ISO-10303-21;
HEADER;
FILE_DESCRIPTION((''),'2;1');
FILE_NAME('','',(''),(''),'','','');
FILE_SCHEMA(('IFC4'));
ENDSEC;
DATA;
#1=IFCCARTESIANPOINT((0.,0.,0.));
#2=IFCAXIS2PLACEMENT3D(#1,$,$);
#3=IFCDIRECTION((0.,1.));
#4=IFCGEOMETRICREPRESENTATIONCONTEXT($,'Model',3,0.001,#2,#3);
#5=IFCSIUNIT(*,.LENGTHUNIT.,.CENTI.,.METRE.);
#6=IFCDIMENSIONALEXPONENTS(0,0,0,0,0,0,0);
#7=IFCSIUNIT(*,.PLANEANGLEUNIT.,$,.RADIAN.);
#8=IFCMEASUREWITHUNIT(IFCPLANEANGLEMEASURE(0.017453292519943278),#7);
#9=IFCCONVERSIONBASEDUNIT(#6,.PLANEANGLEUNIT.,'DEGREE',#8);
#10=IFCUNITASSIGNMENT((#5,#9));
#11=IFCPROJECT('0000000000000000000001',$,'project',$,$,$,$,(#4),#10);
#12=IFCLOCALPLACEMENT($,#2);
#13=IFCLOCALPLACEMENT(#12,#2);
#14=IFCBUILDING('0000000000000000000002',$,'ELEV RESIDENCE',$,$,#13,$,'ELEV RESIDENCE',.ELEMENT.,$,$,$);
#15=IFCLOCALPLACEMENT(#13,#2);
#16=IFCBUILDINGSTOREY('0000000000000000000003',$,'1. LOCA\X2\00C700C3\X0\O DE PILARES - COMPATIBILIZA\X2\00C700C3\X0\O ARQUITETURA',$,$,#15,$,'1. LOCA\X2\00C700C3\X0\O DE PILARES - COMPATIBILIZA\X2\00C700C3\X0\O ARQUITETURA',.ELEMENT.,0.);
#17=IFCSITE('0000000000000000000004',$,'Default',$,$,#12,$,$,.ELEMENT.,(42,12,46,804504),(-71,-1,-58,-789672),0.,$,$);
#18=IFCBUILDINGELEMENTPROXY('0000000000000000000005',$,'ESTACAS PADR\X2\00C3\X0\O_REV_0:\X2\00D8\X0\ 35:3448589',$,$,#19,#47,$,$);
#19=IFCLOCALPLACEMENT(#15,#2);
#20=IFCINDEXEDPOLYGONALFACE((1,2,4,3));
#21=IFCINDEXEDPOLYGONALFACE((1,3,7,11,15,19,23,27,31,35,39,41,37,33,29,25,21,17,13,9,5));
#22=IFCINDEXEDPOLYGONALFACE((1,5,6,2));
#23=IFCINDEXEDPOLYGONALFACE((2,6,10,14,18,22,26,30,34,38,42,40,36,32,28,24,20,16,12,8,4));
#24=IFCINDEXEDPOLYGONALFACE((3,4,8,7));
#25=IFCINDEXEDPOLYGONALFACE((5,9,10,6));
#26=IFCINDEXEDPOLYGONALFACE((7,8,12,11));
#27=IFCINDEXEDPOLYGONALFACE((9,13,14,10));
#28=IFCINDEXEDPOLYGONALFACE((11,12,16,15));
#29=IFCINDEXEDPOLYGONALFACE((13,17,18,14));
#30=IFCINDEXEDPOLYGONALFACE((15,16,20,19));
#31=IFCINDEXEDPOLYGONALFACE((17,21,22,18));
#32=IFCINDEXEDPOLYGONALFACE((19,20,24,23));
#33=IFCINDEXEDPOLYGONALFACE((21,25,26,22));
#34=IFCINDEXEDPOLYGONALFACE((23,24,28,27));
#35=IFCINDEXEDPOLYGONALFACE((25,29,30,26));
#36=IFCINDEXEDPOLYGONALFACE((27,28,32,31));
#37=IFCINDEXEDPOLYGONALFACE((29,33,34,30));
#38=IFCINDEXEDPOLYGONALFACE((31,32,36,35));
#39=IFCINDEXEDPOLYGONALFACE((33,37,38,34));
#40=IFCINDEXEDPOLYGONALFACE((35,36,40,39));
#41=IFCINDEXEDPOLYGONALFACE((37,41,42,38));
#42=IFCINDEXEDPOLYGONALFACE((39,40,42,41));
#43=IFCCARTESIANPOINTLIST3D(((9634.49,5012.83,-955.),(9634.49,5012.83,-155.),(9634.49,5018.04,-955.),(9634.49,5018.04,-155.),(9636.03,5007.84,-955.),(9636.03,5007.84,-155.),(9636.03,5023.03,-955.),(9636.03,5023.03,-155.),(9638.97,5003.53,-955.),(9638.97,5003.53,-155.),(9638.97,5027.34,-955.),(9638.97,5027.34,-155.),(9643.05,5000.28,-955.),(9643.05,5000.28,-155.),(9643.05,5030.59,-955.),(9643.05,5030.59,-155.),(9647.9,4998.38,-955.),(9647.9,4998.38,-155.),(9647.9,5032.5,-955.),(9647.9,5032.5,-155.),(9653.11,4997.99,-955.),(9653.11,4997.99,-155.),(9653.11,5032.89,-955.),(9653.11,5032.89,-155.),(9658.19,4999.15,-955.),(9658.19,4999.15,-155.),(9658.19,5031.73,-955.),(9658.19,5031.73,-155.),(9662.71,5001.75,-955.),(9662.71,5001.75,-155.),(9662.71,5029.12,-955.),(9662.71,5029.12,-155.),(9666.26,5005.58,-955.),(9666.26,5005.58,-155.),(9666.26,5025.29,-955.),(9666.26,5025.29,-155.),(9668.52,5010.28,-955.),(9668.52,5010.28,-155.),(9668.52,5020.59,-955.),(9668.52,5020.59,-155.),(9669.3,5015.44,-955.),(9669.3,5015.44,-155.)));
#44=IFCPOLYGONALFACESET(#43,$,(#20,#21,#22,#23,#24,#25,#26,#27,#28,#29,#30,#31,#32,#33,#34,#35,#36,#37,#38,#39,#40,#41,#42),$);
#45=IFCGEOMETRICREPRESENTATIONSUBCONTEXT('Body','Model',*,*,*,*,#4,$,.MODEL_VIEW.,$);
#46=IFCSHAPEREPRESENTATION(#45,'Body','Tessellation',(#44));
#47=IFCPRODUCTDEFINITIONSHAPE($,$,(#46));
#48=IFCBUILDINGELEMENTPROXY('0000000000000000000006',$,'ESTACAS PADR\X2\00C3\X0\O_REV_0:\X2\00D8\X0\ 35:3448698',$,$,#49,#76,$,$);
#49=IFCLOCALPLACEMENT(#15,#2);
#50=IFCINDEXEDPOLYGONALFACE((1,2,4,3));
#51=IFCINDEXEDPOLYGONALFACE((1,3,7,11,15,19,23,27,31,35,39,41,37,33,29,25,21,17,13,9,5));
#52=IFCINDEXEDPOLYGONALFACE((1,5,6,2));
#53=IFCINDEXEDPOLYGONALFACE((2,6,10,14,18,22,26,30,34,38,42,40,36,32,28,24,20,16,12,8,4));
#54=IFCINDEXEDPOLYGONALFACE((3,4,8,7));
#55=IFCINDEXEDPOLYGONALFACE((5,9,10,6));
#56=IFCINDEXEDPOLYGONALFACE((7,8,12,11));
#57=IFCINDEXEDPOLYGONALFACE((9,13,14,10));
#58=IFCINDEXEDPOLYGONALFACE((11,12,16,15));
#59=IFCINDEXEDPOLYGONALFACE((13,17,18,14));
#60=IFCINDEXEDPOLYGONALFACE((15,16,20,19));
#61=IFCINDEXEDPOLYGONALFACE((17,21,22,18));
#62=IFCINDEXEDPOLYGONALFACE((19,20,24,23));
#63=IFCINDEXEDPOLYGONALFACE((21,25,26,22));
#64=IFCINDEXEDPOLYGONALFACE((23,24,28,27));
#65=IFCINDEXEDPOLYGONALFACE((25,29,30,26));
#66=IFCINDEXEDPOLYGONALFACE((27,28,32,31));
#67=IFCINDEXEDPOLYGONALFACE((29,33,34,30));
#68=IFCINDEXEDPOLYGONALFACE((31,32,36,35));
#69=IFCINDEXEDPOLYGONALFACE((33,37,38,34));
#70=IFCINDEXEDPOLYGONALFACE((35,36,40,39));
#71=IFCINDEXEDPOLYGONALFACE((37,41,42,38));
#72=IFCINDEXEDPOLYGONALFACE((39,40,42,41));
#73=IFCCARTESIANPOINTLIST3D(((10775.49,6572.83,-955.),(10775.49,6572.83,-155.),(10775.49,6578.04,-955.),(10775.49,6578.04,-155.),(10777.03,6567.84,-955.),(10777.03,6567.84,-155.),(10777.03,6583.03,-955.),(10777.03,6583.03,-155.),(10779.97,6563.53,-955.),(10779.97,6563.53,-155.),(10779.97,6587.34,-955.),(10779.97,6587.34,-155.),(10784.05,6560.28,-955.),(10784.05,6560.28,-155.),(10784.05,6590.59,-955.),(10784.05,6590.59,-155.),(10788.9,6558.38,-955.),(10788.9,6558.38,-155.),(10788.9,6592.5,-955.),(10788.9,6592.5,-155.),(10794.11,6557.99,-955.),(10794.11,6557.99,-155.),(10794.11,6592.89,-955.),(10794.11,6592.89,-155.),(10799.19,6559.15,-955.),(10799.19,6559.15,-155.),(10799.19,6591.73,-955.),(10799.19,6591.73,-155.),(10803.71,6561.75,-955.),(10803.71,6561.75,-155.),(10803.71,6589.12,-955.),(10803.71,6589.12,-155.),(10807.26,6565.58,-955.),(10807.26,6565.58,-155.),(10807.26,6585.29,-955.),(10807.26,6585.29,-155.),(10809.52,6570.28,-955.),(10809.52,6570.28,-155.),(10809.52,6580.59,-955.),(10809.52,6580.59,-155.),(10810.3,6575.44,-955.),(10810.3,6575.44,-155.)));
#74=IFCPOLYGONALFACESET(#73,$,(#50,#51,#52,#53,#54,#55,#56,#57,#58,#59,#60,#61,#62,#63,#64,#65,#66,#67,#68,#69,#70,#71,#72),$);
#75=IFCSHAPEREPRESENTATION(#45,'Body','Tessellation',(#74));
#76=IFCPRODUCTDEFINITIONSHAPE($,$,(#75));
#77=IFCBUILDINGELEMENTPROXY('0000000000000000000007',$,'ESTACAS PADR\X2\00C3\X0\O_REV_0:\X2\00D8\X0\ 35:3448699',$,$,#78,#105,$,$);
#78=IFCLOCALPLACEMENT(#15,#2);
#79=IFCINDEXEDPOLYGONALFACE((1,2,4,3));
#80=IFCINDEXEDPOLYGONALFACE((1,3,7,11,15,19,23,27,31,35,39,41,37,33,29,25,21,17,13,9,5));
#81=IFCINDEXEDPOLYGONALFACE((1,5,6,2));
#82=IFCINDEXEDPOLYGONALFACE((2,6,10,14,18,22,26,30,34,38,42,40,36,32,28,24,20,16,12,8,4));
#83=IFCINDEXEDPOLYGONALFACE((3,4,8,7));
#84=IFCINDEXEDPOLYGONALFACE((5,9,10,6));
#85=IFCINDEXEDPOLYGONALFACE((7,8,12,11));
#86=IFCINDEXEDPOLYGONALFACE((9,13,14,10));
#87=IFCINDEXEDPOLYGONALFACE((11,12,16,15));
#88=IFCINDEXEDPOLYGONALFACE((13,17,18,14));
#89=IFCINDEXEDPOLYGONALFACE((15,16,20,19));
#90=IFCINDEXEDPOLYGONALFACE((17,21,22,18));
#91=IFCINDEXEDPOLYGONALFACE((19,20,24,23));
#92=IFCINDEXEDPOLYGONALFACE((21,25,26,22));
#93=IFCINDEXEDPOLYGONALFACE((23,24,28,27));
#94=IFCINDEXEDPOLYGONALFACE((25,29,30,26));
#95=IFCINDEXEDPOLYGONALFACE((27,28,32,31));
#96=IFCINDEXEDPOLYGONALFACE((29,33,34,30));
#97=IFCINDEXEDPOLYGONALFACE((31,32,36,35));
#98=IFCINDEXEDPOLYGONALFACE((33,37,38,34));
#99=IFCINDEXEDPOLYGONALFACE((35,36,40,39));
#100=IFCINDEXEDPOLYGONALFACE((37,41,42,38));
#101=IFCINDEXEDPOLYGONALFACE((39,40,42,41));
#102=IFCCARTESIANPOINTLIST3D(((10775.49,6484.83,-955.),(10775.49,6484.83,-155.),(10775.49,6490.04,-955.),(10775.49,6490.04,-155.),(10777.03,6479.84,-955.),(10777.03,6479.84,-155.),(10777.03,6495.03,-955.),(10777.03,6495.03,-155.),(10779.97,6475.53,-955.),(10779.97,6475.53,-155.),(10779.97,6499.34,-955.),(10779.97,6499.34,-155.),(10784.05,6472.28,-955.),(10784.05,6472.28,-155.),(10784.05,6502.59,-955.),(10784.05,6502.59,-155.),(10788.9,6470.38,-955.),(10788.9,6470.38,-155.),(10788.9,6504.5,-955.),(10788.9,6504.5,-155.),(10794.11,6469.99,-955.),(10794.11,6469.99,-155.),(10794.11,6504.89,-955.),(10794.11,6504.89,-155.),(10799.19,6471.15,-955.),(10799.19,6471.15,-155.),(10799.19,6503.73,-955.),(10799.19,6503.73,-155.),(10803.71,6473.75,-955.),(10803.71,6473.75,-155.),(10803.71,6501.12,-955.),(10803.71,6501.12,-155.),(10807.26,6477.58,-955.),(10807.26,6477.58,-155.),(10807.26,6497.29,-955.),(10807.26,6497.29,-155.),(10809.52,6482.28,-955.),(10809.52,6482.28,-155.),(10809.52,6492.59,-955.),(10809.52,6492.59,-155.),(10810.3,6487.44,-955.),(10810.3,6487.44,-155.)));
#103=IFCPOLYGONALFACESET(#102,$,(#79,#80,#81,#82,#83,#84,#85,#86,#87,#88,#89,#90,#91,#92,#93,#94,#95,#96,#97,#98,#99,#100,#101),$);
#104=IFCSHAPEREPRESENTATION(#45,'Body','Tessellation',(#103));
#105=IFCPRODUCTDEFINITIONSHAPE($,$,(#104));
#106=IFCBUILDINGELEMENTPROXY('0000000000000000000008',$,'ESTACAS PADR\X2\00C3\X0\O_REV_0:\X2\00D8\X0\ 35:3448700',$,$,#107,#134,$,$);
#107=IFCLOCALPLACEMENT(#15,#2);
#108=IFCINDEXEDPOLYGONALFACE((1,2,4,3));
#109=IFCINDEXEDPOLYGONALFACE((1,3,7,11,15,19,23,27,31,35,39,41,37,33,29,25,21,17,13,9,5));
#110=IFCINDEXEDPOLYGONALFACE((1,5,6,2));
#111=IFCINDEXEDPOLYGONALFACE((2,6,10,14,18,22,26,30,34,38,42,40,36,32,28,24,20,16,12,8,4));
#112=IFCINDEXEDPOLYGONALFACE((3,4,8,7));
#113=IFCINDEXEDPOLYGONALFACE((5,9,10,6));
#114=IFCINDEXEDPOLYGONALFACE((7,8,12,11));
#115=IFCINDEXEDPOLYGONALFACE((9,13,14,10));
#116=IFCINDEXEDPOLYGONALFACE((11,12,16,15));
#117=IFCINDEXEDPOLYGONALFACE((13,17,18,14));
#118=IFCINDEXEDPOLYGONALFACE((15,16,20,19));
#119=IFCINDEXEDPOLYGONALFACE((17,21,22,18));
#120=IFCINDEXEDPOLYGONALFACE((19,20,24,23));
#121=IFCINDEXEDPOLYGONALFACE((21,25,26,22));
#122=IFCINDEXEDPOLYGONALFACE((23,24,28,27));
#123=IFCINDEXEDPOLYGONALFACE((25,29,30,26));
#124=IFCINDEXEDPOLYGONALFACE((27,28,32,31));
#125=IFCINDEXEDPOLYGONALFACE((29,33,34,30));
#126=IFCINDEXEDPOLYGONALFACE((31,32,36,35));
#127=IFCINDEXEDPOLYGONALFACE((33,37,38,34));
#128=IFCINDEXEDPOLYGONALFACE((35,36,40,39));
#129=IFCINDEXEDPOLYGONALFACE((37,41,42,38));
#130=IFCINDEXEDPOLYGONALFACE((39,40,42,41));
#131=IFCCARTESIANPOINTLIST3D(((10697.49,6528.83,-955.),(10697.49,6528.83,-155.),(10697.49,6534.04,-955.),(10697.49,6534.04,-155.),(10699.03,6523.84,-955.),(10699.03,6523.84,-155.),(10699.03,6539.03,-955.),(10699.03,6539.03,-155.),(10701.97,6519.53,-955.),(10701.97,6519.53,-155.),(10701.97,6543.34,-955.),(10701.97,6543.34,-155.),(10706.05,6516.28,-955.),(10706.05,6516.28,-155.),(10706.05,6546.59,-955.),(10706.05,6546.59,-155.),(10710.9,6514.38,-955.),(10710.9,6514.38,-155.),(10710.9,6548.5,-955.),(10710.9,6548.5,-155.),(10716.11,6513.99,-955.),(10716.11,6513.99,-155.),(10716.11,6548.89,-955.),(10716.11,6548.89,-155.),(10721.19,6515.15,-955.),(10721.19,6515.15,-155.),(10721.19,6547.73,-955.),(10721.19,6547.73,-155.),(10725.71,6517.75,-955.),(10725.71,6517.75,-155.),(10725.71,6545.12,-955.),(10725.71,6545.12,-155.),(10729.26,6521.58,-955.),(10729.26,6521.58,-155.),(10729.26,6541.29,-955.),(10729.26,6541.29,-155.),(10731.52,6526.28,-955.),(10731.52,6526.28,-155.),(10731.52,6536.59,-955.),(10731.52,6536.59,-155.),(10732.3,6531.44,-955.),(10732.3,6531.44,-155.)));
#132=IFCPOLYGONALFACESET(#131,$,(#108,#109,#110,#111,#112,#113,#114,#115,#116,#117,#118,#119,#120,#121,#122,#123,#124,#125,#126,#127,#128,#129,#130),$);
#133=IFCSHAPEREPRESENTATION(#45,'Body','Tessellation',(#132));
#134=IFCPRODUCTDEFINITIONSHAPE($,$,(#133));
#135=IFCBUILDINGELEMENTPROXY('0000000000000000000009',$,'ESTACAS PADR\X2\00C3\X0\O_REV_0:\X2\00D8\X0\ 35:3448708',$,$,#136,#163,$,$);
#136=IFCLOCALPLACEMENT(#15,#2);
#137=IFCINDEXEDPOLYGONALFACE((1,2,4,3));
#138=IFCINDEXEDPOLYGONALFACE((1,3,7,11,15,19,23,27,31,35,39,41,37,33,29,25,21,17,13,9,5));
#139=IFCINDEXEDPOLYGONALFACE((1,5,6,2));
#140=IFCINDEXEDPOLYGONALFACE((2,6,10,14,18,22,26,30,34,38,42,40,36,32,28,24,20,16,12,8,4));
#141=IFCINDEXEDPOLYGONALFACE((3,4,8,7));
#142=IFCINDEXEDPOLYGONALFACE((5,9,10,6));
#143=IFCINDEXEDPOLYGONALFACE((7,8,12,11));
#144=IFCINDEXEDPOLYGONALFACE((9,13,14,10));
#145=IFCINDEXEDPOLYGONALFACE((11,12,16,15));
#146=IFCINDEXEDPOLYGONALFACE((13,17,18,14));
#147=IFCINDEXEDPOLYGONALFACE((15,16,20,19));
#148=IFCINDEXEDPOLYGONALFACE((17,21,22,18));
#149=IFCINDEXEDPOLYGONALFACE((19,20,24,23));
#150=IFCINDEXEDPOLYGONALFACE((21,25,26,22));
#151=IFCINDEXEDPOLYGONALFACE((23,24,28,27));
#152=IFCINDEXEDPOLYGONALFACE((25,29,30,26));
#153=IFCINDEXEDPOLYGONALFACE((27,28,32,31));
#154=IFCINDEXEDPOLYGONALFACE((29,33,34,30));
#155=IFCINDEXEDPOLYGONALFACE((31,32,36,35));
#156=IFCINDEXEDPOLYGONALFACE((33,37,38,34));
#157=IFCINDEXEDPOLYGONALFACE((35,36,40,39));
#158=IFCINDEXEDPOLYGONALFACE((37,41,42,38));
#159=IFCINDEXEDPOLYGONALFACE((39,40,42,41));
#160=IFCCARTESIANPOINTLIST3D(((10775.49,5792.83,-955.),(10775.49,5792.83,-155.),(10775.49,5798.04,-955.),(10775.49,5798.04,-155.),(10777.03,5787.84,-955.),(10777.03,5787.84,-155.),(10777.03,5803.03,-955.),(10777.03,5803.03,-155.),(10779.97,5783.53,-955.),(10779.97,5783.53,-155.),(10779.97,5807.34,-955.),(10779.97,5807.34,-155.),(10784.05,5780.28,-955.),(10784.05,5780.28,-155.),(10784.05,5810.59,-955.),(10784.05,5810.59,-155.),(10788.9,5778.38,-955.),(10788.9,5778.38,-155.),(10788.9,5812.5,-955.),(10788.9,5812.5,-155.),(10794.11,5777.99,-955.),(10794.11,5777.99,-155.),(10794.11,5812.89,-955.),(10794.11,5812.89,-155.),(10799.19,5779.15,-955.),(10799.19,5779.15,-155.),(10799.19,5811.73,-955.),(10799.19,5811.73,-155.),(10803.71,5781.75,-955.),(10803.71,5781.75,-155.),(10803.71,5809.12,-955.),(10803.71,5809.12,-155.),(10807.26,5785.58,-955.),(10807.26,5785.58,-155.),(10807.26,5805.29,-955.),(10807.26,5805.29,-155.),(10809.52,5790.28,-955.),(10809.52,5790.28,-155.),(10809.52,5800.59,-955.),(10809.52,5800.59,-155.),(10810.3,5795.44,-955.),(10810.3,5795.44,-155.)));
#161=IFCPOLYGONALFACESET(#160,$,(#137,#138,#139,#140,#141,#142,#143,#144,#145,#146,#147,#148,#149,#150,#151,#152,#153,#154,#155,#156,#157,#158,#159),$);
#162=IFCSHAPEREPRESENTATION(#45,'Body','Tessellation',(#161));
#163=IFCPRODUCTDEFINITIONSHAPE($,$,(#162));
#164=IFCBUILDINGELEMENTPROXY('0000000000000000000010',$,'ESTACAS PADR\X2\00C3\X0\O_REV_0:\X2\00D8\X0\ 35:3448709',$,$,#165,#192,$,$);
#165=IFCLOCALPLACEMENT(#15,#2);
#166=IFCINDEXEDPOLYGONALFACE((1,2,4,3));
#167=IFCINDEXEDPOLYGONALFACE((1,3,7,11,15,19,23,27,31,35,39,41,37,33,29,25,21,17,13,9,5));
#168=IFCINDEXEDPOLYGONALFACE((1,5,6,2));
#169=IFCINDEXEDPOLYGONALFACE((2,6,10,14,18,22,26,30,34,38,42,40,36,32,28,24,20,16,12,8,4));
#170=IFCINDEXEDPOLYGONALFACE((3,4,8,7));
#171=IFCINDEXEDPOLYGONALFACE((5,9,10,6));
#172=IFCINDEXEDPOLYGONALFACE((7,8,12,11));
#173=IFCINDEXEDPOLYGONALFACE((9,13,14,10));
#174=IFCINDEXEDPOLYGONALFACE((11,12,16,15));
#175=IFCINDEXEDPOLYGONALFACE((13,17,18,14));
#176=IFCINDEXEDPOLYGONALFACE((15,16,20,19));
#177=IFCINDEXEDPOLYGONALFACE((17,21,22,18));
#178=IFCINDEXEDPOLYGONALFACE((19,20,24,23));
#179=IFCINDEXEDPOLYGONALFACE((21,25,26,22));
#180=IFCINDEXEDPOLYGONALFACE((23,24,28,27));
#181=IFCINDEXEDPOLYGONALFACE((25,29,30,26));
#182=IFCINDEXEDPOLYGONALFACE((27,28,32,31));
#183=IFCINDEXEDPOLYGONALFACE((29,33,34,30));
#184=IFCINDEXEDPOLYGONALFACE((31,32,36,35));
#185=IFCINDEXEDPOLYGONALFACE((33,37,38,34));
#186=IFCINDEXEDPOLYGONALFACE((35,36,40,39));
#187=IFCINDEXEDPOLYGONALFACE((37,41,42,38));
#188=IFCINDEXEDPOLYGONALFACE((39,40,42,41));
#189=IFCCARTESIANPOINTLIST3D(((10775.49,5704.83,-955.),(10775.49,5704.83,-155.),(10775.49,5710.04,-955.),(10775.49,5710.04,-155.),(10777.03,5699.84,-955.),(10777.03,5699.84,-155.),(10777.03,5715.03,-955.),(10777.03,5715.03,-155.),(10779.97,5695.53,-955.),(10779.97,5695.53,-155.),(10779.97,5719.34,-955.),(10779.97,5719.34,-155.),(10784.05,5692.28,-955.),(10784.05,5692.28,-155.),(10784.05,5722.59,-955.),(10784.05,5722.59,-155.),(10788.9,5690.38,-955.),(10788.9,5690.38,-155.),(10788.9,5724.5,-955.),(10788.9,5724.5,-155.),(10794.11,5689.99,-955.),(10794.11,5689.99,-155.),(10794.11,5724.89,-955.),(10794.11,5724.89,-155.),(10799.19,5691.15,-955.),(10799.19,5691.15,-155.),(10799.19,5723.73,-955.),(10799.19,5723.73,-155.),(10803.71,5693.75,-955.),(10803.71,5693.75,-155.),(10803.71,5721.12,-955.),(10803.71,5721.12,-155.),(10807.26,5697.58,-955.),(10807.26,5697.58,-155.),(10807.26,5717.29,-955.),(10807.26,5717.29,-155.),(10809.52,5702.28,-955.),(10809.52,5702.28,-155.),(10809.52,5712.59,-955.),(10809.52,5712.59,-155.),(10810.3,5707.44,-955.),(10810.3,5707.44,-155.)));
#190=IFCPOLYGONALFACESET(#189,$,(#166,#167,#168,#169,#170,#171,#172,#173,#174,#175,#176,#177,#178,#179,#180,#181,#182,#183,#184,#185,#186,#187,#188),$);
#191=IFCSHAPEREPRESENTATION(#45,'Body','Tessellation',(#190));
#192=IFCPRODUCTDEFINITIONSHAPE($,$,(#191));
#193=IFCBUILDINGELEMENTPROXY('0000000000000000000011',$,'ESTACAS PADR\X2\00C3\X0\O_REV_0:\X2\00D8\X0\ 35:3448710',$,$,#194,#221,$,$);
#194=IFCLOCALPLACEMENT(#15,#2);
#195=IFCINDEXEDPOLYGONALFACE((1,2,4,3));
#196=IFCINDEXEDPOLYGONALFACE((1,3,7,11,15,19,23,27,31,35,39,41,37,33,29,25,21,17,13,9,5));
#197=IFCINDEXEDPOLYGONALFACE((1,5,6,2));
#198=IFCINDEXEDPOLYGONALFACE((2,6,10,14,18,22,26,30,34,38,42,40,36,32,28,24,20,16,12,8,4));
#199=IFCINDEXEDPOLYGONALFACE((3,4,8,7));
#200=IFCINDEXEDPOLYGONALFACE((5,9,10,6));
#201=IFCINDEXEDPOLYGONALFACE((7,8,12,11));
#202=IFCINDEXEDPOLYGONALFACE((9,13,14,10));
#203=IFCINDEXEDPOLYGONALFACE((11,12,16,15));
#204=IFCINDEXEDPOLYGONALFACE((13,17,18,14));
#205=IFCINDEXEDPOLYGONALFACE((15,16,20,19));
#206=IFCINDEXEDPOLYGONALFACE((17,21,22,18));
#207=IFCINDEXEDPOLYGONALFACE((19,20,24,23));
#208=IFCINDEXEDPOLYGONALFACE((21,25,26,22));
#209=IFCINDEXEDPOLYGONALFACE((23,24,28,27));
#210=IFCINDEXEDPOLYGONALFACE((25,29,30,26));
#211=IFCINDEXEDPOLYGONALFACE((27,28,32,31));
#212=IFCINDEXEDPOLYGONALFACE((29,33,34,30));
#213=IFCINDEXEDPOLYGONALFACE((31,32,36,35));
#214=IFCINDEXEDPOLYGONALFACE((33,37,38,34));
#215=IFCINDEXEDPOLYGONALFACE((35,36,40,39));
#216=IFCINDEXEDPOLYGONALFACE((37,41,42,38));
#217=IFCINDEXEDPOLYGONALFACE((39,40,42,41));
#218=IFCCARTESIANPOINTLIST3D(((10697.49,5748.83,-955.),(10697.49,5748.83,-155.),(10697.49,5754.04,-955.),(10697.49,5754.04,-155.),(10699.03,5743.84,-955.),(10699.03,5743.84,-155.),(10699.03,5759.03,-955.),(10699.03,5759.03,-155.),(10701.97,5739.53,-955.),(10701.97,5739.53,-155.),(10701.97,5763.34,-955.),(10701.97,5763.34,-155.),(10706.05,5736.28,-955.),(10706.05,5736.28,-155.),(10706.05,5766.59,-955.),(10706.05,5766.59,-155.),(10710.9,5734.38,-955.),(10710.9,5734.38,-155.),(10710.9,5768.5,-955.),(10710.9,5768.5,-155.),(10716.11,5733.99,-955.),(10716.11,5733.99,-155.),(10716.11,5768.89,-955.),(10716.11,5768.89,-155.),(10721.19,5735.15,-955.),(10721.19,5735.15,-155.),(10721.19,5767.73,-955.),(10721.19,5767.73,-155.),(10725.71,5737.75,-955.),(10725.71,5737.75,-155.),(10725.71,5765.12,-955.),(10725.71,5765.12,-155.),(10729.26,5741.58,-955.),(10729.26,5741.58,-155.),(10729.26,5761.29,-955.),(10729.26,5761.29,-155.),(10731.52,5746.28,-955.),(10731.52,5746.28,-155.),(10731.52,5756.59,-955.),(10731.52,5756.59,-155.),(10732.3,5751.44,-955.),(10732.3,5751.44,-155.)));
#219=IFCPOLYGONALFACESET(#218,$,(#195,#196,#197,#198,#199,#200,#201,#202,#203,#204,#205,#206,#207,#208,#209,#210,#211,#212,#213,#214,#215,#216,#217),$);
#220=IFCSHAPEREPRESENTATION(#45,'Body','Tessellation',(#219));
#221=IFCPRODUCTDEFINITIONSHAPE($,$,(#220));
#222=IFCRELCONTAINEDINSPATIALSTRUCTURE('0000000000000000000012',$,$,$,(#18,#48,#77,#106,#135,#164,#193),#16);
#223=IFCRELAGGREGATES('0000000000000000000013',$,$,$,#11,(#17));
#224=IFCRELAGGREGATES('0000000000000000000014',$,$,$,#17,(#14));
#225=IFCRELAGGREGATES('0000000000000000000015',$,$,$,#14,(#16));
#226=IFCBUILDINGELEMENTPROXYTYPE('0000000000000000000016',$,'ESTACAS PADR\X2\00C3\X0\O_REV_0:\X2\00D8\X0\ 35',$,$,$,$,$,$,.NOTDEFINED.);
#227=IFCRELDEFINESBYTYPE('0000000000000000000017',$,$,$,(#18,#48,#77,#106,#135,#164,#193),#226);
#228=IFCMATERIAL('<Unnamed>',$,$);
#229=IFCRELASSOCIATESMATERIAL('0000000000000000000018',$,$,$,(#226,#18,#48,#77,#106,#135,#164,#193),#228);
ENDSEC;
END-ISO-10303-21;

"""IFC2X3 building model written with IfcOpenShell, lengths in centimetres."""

from ifc_helpers import new_model, entity, si_unit, converted_unit, direction, frame, frame_2d, origin, place, context, subcontext, project, spatial, circle, extrude, source, transform, mapped, material, type_object, type_shapes, element, save


model = new_model("IFC2X3")

# Units and contexts
model_context = context("Model", 3, precision=0.001, world=origin(), true_north=direction((0.0, 1.0)))
body_context = subcontext(model_context, "Body", "Model", "MODEL_VIEW")
ifc_project = project(units=[si_unit("LENGTHUNIT", "METRE", prefix="CENTI"), converted_unit("PLANEANGLEUNIT", "DEGREE", entity("IfcPlaneAngleMeasure", 0.017453292519943278), si_unit("PLANEANGLEUNIT", "RADIAN"), dimensions=[0, 0, 0, 0, 0, 0, 0])], contexts=[model_context])

# Site, building, storey
site_placement = place(None, origin())
site = spatial("IfcSite", under=ifc_project, at=site_placement, Name="Default", CompositionType="ELEMENT", RefLatitude=(42, 12, 46, 804504), RefLongitude=(-71, -1, -58, -789672), RefElevation=0.0)
building_placement = place(site_placement, origin())
building = spatial("IfcBuilding", under=site, at=building_placement, Name="ELEV RESIDENCE", LongName="ELEV RESIDENCE", CompositionType="ELEMENT")
storey_placement = place(building_placement, origin())
storey = spatial("IfcBuildingStorey", under=building, at=storey_placement, Name="1. LOCAÇÃO DE PILARES - COMPATIBILIZAÇÃO ARQUITETURA", LongName="1. LOCAÇÃO DE PILARES - COMPATIBILIZAÇÃO ARQUITETURA", CompositionType="ELEMENT", Elevation=0.0)

# Building element proxies
ifc_material_1 = material(Name="<Unnamed>")
building_element_proxy_type_1 = type_object("IfcBuildingElementProxyType", Name="ESTACAS PADRÃO_REV_0:Ø 35", PredefinedType="NOTDEFINED", material=ifc_material_1)
shared_shape_1 = source(origin(), body_context, "Body", "SweptSolid", [
    extrude(circle(Radius=17.5, at=frame_2d((0.0, 0.0), x_axis=(1.0, 0.0))), frame((0.0, 0.0, -955.0)), (0.0, 0.0, 1.0), 800.0),
])
type_shapes(building_element_proxy_type_1, [shared_shape_1])
for number, where, name in (
    (1, (9651.8, 5015.44, 0.0), "ESTACAS PADRÃO_REV_0:Ø 35:3448589"),
    (2, (10792.8, 6575.44, 0.0), "ESTACAS PADRÃO_REV_0:Ø 35:3448698"),
    (3, (10792.8, 6487.44, 0.0), "ESTACAS PADRÃO_REV_0:Ø 35:3448699"),
    (4, (10714.8, 6531.44, 0.0), "ESTACAS PADRÃO_REV_0:Ø 35:3448700"),
    (5, (10792.8, 5795.44, 0.0), "ESTACAS PADRÃO_REV_0:Ø 35:3448708"),
    (6, (10792.8, 5707.44, 0.0), "ESTACAS PADRÃO_REV_0:Ø 35:3448709"),
    (7, (10714.8, 5751.44, 0.0), "ESTACAS PADRÃO_REV_0:Ø 35:3448710"),
):
    element("IfcBuildingElementProxy", number, at=place(storey_placement, frame(where)), inside=storey, type_object=building_element_proxy_type_1, material=ifc_material_1, Name=name, context=body_context, shape_type="MappedRepresentation", body=[
        mapped(shared_shape_1, transform((0.0, 0.0, 0.0), scale=1.0)),
    ])

save(model, "model.ifc")
